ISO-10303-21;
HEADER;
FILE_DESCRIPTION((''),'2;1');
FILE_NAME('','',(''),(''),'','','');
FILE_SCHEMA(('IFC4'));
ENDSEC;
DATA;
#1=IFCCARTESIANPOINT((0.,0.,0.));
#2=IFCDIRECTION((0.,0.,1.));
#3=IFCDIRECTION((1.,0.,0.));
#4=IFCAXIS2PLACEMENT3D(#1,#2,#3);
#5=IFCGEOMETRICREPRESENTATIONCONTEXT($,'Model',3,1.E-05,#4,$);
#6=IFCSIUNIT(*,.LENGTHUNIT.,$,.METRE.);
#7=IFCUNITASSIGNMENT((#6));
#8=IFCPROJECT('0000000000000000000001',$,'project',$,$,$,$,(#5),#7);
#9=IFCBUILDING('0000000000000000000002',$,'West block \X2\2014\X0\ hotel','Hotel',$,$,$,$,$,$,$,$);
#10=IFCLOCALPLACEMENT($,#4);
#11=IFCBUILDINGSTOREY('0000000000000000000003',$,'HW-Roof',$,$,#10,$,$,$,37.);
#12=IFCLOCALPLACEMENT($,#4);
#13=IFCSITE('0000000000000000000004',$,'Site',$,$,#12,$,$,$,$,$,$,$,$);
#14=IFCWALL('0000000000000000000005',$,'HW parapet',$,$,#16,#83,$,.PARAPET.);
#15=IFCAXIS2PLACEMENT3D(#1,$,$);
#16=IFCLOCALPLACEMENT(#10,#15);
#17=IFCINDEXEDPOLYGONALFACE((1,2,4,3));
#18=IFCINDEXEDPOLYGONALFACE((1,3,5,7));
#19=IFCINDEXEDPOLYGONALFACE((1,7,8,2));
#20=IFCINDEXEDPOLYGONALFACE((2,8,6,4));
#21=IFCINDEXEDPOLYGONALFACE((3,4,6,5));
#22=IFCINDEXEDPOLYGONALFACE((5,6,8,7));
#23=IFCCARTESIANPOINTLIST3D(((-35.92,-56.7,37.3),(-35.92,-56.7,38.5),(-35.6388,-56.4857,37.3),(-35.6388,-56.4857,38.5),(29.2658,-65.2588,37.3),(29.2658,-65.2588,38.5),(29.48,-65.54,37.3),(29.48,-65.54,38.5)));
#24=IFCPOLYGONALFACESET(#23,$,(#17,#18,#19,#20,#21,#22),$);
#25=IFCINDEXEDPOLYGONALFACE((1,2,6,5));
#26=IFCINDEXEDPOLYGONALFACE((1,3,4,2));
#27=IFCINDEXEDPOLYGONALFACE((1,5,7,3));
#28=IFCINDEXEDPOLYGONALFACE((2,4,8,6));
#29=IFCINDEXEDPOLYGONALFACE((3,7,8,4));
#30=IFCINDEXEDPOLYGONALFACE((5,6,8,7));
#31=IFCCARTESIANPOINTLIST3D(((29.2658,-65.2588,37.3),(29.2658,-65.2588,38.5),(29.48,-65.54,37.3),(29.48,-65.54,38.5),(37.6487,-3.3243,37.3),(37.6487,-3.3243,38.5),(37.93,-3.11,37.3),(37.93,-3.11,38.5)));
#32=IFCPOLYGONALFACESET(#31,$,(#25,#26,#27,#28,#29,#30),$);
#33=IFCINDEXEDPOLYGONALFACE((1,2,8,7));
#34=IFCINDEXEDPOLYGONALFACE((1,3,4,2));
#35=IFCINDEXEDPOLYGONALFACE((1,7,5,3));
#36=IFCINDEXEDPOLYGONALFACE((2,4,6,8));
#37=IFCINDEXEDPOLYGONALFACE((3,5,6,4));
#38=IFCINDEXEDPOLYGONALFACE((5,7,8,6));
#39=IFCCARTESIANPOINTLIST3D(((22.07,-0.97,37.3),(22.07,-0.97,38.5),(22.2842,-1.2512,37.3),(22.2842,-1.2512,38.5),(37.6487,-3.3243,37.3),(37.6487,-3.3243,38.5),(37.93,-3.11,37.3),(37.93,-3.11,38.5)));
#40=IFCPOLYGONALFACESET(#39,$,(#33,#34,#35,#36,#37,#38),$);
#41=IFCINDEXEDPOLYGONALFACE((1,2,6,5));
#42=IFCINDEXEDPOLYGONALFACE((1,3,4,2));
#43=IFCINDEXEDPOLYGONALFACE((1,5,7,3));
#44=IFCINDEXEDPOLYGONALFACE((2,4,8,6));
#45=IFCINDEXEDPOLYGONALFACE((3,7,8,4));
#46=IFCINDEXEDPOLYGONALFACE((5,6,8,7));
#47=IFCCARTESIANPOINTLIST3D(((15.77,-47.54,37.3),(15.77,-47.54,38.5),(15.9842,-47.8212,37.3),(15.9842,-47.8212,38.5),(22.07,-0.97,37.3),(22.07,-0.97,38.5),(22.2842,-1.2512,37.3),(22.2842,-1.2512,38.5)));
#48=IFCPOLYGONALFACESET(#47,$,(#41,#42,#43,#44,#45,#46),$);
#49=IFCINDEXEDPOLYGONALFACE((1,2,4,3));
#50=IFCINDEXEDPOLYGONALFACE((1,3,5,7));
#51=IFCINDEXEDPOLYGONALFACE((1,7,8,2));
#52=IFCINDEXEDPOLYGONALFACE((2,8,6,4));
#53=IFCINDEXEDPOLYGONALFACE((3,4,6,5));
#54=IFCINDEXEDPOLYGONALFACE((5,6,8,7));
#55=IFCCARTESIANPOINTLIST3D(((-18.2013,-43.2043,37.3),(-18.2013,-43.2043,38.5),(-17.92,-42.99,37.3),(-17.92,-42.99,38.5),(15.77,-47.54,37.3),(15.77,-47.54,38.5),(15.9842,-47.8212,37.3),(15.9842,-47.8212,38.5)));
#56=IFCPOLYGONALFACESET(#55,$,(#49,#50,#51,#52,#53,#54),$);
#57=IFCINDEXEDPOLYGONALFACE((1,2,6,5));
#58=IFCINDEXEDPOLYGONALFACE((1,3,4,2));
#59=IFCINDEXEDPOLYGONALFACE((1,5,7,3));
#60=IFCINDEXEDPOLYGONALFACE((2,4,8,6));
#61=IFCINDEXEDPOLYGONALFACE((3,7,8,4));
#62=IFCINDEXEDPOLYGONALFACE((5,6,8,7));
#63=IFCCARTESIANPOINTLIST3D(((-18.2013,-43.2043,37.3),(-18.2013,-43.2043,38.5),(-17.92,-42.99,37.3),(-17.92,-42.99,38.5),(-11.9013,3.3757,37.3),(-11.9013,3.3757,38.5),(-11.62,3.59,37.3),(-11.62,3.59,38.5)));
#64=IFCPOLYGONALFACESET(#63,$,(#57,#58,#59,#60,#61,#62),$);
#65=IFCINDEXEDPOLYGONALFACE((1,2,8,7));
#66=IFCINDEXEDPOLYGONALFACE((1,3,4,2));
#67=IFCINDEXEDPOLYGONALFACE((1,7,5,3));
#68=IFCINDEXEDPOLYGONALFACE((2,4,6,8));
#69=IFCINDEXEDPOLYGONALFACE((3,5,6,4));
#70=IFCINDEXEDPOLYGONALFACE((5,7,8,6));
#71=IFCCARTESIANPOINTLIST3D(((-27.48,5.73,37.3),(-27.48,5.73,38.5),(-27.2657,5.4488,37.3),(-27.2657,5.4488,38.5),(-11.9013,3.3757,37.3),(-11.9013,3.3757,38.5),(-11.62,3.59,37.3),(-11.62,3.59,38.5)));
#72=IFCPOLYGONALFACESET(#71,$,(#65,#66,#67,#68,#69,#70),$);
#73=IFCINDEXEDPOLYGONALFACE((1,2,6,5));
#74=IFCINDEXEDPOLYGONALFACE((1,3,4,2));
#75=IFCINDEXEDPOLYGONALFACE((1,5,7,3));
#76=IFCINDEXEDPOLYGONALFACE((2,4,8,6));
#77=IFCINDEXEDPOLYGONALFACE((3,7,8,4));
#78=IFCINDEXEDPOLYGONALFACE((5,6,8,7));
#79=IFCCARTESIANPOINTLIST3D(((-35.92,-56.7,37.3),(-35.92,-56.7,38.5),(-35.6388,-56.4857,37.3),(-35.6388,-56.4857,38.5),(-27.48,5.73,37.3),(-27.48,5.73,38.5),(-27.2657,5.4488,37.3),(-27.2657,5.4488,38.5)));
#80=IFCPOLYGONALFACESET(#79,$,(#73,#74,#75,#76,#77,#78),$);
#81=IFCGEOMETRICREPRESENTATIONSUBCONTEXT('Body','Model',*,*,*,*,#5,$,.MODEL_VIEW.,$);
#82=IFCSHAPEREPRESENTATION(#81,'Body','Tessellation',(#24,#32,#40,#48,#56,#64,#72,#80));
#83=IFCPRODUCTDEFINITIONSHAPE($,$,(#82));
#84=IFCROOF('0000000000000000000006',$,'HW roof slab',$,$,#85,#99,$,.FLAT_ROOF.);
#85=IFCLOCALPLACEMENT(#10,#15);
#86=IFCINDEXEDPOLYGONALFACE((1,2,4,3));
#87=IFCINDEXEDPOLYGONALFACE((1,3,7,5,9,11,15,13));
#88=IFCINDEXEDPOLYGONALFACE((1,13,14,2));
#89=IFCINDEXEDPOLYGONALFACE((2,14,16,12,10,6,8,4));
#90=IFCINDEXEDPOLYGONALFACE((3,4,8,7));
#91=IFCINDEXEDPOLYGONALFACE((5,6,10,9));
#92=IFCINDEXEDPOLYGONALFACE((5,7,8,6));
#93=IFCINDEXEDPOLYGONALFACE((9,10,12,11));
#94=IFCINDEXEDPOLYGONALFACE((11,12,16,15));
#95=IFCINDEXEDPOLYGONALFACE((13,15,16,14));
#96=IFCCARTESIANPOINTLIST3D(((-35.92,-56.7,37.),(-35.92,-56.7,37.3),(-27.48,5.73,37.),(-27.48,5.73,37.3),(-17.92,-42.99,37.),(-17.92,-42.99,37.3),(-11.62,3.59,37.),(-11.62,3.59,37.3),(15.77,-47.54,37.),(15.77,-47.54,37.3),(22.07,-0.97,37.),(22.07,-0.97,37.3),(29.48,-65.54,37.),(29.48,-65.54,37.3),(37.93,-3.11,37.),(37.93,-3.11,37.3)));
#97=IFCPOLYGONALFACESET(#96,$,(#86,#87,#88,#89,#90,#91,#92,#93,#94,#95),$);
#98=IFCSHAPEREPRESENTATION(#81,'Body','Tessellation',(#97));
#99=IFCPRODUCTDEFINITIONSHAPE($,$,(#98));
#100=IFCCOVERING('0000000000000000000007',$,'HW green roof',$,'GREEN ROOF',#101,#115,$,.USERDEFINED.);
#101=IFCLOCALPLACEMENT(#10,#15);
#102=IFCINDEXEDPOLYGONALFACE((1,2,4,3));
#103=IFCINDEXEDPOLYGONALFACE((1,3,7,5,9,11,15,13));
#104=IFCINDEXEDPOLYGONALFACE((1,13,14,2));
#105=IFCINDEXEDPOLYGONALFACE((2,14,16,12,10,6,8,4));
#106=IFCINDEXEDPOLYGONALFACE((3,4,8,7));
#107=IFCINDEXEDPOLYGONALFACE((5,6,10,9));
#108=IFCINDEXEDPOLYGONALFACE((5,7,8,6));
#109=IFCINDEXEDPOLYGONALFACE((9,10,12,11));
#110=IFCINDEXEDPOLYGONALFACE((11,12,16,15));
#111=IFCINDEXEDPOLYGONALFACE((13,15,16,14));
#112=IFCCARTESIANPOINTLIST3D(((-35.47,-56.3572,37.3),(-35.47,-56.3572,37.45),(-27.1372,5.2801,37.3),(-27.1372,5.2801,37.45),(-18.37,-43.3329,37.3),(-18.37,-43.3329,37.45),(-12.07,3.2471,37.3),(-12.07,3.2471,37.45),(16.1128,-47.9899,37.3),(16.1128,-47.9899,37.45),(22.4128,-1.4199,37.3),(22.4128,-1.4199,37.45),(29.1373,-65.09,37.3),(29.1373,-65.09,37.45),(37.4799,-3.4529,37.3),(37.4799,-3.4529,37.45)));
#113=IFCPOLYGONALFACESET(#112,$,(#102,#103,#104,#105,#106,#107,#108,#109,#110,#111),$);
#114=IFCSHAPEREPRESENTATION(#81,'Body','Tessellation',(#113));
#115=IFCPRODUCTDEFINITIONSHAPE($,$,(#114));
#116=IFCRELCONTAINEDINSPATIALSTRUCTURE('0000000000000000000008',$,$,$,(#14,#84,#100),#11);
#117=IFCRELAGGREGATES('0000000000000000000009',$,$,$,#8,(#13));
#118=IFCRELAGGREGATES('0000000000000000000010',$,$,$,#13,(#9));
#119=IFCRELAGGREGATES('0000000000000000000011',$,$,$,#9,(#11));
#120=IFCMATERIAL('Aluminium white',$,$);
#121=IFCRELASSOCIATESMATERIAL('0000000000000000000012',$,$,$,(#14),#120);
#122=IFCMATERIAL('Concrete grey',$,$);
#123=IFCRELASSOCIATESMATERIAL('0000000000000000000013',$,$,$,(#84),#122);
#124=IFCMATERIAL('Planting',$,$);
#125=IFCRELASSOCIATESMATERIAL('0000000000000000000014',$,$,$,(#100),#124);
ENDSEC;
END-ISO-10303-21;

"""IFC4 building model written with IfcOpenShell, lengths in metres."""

from ifc_helpers import new_model, si_unit, frame, origin_with_axes, place, context, subcontext, project, spatial, polyline, outline, extrude, material, element, save


model = new_model("IFC4")

# Units and contexts
model_context = context("Model", 3, precision=1e-05, world=origin_with_axes())
body_context = subcontext(model_context, "Body", "Model", "MODEL_VIEW")
ifc_project = project(units=[si_unit("LENGTHUNIT", "METRE")], contexts=[model_context])

# Site, building, storey
site_placement = place(None, origin_with_axes())
site = spatial("IfcSite", under=ifc_project, at=site_placement, Name="Site")
building = spatial("IfcBuilding", under=site, Name="West block — hotel", Description="Hotel")
storey_placement = place(None, origin_with_axes())
storey = spatial("IfcBuildingStorey", under=building, at=storey_placement, Name="HW-Roof", Elevation=37.0)

# Wall
ifc_material_1 = material(Name="Aluminium white")
wall_placement = place(storey_placement, origin_with_axes())
element("IfcWall", 1, at=wall_placement, inside=storey, material=ifc_material_1, Name="HW parapet", PredefinedType="PARAPET", context=body_context, shape_type="SweptSolid", body=[
    extrude(outline(polyline([(-35.92, -56.7), (29.48, -65.54), (29.2658, -65.2588), (-35.6388, -56.4857), (-35.92, -56.7)])), frame((0.0, 0.0, 37.3), z_axis=(0.0, 0.0, 1.0), x_axis=(1.0, 0.0, 0.0)), (0.0, 0.0, 1.0), 1.2),
    extrude(outline(polyline([(29.48, -65.54), (37.93, -3.11), (37.6487, -3.3243), (29.2658, -65.2588), (29.48, -65.54)])), frame((0.0, 0.0, 37.3), z_axis=(0.0, 0.0, 1.0), x_axis=(1.0, 0.0, 0.0)), (0.0, 0.0, 1.0), 1.2),
    extrude(outline(polyline([(37.93, -3.11), (22.07, -0.97), (22.2842, -1.2512), (37.6487, -3.3243), (37.93, -3.11)])), frame((0.0, 0.0, 37.3), z_axis=(0.0, 0.0, 1.0), x_axis=(1.0, 0.0, 0.0)), (0.0, 0.0, 1.0), 1.2),
    extrude(outline(polyline([(22.07, -0.97), (15.77, -47.54), (15.9842, -47.8212), (22.2842, -1.2512), (22.07, -0.97)])), frame((0.0, 0.0, 37.3), z_axis=(0.0, 0.0, 1.0), x_axis=(1.0, 0.0, 0.0)), (0.0, 0.0, 1.0), 1.2),
    extrude(outline(polyline([(15.77, -47.54), (-17.92, -42.99), (-18.2013, -43.2043), (15.9842, -47.8212), (15.77, -47.54)])), frame((0.0, 0.0, 37.3), z_axis=(0.0, 0.0, 1.0), x_axis=(1.0, 0.0, 0.0)), (0.0, 0.0, 1.0), 1.2),
    extrude(outline(polyline([(-17.92, -42.99), (-11.62, 3.59), (-11.9013, 3.3757), (-18.2013, -43.2043), (-17.92, -42.99)])), frame((0.0, 0.0, 37.3), z_axis=(0.0, 0.0, 1.0), x_axis=(1.0, 0.0, 0.0)), (0.0, 0.0, 1.0), 1.2),
    extrude(outline(polyline([(-11.62, 3.59), (-27.48, 5.73), (-27.2657, 5.4488), (-11.9013, 3.3757), (-11.62, 3.59)])), frame((0.0, 0.0, 37.3), z_axis=(0.0, 0.0, 1.0), x_axis=(1.0, 0.0, 0.0)), (0.0, 0.0, 1.0), 1.2),
    extrude(outline(polyline([(-27.48, 5.73), (-35.92, -56.7), (-35.6388, -56.4857), (-27.2657, 5.4488), (-27.48, 5.73)])), frame((0.0, 0.0, 37.3), z_axis=(0.0, 0.0, 1.0), x_axis=(1.0, 0.0, 0.0)), (0.0, 0.0, 1.0), 1.2),
])

# Roof
ifc_material_2 = material(Name="Concrete grey")
roof_placement = place(storey_placement, origin_with_axes())
element("IfcRoof", 2, at=roof_placement, inside=storey, material=ifc_material_2, Name="HW roof slab", PredefinedType="FLAT_ROOF", context=body_context, shape_type="SweptSolid", body=[
    extrude(outline(polyline([(-35.92, -56.7), (29.48, -65.54), (37.93, -3.11), (22.07, -0.97), (15.77, -47.54), (-17.92, -42.99), (-11.62, 3.59), (-27.48, 5.73), (-35.92, -56.7)])), frame((0.0, 0.0, 37.0), z_axis=(0.0, 0.0, 1.0), x_axis=(1.0, 0.0, 0.0)), (0.0, 0.0, 1.0), 0.3),
])

# Covering
ifc_material_3 = material(Name="Planting")
covering_placement = place(storey_placement, origin_with_axes())
element("IfcCovering", 3, at=covering_placement, inside=storey, material=ifc_material_3, Name="HW green roof", ObjectType="GREEN ROOF", PredefinedType="USERDEFINED", context=body_context, shape_type="SweptSolid", body=[
    extrude(outline(polyline([(-35.47, -56.3572), (29.1373, -65.09), (37.4799, -3.4529), (22.4128, -1.4199), (16.1128, -47.9899), (-18.37, -43.3329), (-12.07, 3.2471), (-27.1372, 5.2801), (-35.47, -56.3572)])), frame((0.0, 0.0, 37.3), z_axis=(0.0, 0.0, 1.0), x_axis=(1.0, 0.0, 0.0)), (0.0, 0.0, 1.0), 0.15),
])

save(model, "model.ifc")
